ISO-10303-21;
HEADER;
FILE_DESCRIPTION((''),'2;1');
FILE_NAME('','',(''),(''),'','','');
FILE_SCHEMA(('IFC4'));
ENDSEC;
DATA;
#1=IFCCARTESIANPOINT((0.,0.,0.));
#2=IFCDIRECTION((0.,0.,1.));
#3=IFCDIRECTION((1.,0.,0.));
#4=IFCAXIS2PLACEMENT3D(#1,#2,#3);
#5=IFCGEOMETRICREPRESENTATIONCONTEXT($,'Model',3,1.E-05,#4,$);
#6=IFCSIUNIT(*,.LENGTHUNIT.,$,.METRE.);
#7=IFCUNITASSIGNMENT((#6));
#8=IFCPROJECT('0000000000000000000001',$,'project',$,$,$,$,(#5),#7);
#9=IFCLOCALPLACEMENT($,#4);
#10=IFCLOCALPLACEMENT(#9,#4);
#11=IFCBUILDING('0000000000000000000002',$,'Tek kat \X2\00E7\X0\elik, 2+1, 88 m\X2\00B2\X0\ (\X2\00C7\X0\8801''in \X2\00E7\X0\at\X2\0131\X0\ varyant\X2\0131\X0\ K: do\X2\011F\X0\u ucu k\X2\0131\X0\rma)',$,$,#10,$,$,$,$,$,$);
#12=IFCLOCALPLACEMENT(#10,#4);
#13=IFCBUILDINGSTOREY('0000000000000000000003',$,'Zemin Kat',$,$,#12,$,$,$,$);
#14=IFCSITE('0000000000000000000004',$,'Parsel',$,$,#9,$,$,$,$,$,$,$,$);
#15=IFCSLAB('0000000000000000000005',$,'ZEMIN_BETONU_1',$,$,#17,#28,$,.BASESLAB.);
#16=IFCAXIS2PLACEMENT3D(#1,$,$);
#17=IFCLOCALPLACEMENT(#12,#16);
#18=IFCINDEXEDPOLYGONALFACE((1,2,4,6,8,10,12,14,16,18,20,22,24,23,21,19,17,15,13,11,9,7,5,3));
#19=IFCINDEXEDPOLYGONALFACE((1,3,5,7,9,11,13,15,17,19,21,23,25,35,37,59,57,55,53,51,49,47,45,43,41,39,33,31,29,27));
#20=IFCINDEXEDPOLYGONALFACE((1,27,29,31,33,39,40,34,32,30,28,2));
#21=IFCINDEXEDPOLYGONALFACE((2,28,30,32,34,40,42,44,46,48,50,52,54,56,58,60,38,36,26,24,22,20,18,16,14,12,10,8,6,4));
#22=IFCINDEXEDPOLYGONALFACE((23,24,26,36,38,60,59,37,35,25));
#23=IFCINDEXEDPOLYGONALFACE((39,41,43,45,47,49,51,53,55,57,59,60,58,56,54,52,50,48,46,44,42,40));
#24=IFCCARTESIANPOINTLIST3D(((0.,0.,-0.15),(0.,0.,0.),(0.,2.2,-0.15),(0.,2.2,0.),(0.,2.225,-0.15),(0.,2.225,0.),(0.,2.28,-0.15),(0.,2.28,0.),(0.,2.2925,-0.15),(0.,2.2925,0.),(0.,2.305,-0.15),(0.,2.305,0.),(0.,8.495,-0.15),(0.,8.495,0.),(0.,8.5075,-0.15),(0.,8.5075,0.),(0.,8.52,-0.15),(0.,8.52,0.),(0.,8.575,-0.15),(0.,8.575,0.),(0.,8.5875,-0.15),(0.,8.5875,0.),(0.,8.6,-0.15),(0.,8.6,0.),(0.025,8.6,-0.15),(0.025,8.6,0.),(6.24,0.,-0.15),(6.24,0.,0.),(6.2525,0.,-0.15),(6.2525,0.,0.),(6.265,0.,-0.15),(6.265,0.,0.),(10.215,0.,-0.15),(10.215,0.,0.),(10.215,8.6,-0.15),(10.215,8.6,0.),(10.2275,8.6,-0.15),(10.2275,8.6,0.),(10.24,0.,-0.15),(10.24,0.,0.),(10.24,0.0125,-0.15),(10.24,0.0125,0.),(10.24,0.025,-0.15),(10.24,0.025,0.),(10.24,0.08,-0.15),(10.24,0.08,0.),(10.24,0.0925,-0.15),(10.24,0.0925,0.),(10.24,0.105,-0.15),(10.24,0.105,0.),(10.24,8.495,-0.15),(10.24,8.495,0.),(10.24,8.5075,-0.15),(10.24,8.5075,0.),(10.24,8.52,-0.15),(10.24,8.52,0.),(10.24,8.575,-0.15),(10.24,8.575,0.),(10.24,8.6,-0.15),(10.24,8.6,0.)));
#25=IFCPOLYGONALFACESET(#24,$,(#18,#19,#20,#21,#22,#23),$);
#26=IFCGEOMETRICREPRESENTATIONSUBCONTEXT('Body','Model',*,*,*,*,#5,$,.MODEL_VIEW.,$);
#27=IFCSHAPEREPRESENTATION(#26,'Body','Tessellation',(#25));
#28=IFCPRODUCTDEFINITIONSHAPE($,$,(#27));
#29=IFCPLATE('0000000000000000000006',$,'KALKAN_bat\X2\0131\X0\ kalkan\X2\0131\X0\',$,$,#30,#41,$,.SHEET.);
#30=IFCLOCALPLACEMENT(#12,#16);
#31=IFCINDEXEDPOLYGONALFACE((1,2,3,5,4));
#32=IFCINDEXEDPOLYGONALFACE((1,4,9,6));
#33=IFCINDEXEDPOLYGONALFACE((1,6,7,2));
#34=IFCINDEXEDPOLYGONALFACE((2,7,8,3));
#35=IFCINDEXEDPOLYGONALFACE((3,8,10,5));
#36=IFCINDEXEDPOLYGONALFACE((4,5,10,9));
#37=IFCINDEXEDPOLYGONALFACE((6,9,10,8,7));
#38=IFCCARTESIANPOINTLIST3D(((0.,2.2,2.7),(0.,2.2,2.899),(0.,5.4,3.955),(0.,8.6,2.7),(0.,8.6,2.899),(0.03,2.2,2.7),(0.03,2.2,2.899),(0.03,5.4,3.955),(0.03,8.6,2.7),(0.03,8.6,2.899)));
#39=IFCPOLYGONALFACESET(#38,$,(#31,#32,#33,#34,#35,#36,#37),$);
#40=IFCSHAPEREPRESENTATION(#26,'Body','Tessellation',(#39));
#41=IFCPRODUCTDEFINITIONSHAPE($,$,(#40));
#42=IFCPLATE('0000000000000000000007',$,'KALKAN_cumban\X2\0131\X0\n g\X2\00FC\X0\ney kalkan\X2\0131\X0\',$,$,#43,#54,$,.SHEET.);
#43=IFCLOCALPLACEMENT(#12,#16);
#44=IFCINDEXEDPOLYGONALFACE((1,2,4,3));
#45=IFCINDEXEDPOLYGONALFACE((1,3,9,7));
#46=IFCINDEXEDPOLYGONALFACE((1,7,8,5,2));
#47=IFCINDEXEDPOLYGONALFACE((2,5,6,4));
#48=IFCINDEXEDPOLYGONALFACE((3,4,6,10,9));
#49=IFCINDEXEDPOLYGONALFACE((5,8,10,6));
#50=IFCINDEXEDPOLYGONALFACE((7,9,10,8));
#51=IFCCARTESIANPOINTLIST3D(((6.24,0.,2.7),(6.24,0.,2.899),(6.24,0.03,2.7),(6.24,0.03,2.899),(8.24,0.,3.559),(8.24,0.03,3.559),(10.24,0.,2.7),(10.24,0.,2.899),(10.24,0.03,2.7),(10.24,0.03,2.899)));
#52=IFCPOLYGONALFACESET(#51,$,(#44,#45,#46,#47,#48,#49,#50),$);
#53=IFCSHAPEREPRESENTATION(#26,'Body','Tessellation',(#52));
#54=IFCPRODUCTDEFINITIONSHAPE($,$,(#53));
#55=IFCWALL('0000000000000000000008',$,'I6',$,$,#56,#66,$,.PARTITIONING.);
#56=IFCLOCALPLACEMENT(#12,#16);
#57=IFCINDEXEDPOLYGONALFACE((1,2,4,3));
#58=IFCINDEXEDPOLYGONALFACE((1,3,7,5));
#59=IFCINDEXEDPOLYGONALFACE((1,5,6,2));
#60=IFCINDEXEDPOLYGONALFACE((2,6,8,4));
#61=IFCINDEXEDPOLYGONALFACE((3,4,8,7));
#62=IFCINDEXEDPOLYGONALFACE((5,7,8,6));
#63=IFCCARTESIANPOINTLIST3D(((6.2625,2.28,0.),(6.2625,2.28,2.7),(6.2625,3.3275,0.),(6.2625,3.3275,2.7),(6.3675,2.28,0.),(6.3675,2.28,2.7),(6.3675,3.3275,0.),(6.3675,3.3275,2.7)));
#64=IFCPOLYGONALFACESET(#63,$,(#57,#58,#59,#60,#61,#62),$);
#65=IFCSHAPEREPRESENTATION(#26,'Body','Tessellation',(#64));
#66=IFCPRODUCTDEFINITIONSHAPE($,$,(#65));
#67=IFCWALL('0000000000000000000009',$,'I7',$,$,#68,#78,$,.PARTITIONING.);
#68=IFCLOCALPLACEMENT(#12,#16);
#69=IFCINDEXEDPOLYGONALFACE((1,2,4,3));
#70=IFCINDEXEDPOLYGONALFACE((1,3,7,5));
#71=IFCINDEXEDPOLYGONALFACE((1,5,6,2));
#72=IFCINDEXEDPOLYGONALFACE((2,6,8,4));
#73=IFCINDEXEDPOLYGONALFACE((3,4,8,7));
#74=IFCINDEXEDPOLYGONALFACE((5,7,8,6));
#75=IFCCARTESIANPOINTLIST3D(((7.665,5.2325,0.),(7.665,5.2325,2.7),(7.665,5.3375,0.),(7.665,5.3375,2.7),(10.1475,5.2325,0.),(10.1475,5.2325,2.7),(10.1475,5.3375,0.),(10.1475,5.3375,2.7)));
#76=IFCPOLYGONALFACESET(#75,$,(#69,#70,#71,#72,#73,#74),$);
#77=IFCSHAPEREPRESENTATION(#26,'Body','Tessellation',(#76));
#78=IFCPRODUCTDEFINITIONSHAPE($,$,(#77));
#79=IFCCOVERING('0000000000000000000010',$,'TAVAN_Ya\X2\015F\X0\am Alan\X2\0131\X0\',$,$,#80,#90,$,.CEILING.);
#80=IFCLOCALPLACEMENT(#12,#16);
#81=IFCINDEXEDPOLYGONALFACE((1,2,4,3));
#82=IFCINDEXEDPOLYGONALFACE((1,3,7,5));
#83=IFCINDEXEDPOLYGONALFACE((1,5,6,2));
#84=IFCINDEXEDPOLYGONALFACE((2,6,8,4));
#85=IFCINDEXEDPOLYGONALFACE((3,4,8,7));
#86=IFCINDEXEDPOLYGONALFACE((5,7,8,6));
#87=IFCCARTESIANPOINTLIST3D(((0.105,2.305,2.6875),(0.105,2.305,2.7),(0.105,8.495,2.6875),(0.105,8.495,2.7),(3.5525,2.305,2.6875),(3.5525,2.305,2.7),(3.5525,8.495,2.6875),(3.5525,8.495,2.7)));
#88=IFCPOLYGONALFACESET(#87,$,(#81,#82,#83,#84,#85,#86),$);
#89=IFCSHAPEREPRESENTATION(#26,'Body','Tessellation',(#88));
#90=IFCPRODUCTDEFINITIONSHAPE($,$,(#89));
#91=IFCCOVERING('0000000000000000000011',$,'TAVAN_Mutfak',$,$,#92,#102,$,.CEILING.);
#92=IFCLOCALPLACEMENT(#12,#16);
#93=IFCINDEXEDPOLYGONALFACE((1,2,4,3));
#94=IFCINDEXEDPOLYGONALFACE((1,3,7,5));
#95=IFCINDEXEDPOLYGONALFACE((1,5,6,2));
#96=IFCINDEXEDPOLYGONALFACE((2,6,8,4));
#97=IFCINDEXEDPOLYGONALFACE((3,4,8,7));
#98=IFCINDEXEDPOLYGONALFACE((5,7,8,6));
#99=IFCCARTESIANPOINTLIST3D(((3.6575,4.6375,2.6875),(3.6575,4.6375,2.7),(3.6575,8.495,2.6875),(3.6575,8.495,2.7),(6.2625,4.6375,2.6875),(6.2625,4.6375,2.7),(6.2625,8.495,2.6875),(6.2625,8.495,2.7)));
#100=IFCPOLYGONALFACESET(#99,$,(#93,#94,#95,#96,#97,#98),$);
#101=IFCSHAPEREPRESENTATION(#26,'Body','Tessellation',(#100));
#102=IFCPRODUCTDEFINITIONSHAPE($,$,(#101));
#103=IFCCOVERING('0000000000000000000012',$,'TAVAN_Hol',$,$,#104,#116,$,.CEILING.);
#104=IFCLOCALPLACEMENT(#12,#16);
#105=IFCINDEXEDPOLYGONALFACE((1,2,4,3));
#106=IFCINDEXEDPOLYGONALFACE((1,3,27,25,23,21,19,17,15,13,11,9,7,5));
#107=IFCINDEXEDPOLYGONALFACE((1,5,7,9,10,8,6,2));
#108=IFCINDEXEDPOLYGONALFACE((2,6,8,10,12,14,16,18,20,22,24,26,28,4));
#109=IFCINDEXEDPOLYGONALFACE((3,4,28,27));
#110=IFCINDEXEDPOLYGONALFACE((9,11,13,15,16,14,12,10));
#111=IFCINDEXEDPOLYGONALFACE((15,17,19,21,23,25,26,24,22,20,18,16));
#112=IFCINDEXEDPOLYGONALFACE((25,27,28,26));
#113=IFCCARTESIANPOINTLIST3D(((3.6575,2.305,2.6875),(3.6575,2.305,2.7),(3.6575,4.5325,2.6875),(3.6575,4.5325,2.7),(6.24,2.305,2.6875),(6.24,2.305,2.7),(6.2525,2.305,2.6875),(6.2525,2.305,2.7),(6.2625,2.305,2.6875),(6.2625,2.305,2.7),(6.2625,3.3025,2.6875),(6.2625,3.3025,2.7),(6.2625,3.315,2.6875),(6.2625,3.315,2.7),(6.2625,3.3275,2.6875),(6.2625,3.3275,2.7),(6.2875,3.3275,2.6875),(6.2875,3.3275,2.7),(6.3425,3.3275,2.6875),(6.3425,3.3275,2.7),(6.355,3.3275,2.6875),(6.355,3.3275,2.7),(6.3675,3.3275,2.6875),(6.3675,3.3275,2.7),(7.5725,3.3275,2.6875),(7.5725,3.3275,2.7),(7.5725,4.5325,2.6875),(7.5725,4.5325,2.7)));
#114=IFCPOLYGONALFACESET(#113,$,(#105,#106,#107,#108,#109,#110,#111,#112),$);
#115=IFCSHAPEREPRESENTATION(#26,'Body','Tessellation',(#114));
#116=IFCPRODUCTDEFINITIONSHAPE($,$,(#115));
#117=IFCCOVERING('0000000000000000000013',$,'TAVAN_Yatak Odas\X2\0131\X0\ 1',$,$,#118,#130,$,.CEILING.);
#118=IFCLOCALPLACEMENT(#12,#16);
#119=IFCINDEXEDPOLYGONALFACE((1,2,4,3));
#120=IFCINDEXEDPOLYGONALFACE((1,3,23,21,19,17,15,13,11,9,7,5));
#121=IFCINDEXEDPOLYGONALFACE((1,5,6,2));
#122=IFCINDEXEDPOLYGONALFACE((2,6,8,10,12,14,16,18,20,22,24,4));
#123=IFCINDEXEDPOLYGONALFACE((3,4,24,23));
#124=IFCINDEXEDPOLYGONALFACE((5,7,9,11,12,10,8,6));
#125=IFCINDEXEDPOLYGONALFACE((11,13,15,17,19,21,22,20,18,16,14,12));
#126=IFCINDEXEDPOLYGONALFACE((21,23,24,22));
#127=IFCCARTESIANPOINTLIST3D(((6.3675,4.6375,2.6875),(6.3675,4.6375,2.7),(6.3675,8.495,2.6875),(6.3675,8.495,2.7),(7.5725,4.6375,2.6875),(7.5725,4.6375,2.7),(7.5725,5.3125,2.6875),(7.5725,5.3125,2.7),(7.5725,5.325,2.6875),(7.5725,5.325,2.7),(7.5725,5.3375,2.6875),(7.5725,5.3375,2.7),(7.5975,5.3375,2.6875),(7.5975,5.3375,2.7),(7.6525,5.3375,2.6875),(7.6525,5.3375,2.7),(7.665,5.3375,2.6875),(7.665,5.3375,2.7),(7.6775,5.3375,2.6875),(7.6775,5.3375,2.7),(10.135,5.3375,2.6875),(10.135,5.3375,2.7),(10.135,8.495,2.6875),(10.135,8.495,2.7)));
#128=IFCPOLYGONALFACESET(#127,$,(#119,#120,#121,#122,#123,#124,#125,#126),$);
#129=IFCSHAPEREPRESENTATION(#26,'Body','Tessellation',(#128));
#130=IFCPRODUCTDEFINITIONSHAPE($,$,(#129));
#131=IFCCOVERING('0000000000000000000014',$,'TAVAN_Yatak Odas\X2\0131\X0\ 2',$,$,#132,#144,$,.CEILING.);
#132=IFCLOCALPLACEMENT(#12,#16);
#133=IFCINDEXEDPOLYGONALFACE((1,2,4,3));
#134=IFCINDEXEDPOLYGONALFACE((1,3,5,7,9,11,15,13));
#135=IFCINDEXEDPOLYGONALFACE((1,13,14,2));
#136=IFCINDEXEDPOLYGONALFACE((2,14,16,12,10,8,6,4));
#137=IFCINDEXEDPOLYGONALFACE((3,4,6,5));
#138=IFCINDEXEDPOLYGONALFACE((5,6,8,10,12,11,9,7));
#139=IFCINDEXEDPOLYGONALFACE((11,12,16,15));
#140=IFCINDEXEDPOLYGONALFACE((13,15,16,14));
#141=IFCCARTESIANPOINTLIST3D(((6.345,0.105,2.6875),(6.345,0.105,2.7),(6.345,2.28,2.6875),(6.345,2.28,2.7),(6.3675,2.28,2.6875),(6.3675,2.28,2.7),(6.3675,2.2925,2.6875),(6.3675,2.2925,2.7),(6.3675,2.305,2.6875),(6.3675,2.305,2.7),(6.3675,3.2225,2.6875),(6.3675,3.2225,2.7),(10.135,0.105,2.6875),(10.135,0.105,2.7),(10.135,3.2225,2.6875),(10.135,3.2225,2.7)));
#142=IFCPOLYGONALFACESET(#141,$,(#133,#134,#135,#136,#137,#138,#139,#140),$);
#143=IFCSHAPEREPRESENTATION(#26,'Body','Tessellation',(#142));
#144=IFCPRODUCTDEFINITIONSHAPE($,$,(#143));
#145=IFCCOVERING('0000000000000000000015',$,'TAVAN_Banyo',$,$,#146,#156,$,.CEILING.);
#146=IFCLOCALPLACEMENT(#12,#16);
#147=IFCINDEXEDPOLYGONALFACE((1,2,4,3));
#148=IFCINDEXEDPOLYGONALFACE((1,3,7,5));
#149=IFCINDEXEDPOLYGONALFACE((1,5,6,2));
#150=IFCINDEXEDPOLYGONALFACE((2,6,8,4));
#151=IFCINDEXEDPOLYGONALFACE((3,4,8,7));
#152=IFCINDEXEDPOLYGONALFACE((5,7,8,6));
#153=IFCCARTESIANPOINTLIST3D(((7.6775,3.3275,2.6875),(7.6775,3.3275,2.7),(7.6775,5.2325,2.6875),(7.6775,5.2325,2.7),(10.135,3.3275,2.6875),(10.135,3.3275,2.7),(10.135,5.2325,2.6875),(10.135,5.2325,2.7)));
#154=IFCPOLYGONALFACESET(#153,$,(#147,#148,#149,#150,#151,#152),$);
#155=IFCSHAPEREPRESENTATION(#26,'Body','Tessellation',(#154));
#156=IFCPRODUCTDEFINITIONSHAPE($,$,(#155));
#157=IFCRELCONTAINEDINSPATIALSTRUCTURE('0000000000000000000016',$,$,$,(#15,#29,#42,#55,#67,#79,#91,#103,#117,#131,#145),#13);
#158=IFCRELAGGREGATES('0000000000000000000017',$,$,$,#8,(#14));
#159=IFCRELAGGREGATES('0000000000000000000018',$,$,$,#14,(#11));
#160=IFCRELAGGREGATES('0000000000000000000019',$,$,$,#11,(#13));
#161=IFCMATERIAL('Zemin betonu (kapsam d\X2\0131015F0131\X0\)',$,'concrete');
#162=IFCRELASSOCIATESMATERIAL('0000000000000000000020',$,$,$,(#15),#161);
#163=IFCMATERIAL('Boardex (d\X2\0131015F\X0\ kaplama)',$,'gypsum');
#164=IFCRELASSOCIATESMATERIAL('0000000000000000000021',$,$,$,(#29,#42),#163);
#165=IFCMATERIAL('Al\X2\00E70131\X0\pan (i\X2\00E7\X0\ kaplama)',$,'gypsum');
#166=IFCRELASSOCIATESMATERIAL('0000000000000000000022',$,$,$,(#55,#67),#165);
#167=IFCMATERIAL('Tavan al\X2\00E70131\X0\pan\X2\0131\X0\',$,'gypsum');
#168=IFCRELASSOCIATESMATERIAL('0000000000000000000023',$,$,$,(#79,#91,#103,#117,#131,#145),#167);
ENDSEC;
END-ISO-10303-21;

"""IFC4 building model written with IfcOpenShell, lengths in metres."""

from ifc_helpers import new_model, si_unit, frame, origin_with_axes, place, context, subcontext, project, spatial, line, indexed_curve, outline, extrude, material, element, save


model = new_model("IFC4")

# Units and contexts
model_context = context("Model", 3, precision=1e-05, world=origin_with_axes())
body_context = subcontext(model_context, "Body", "Model", "MODEL_VIEW")
ifc_project = project(units=[si_unit("LENGTHUNIT", "METRE")], contexts=[model_context])

# Site, building, storey
site_placement = place(None, origin_with_axes())
site = spatial("IfcSite", under=ifc_project, at=site_placement, Name="Parsel")
building_placement = place(site_placement, origin_with_axes())
building = spatial("IfcBuilding", under=site, at=building_placement, Name="Tek kat çelik, 2+1, 88 m² (Ç8801'in çatı varyantı K: doğu ucu kırma)")
storey_placement = place(building_placement, origin_with_axes())
storey = spatial("IfcBuildingStorey", under=building, at=storey_placement, Name="Zemin Kat")

# Slab
ifc_material_1 = material(Name="Zemin betonu (kapsam dışı)", Category="concrete")
slab_placement = place(storey_placement, origin_with_axes())
element("IfcSlab", 1, at=slab_placement, inside=storey, material=ifc_material_1, Name="ZEMIN_BETONU_1", PredefinedType="BASESLAB", context=body_context, shape_type="SweptSolid", body=[
    extrude(outline(indexed_curve([(6.24, 0.0), (6.2525, 0.0), (6.265, 0.0), (10.215, 0.0), (10.24, 0.0), (10.24, 0.0125), (10.24, 0.025), (10.24, 0.08), (10.24, 0.0925), (10.24, 0.105), (10.24, 8.495), (10.24, 8.5075), (10.24, 8.52), (10.24, 8.575), (10.24, 8.6), (10.2275, 8.6), (10.215, 8.6), (0.025, 8.6), (0.0, 8.6), (0.0, 8.5875), (0.0, 8.575), (0.0, 8.52), (0.0, 8.5075), (0.0, 8.495), (0.0, 2.305), (0.0, 2.2925), (0.0, 2.28), (0.0, 2.225), (0.0, 2.2), (0.0, 0.0)], segments=[line(1, 2, 3, 4, 5, 6, 7, 8, 9, 10, 11, 12, 13, 14, 15, 16, 17, 18, 19, 20, 21, 22, 23, 24, 25, 26, 27, 28, 29, 30, 1)])), frame((0.0, 0.0, -0.15), z_axis=(0.0, 0.0, 1.0), x_axis=(1.0, 0.0, 0.0)), (0.0, 0.0, 1.0), 0.15),
])

# Plates
ifc_material_2 = material(Name="Boardex (dış kaplama)", Category="gypsum")
plate_1_placement = place(storey_placement, origin_with_axes())
element("IfcPlate", 2, at=plate_1_placement, inside=storey, material=ifc_material_2, Name="KALKAN_batı kalkanı", PredefinedType="SHEET", context=body_context, shape_type="SweptSolid", body=[
    extrude(outline(indexed_curve([(2.2, 2.899), (5.4, 3.955), (8.6, 2.899), (8.6, 2.7), (2.2, 2.7)], segments=[line(1, 2, 3, 4, 5, 1)])), frame((0.0, 0.0, 0.0), z_axis=(1.0, 0.0, 0.0), x_axis=(0.0, 1.0, 0.0)), (0.0, 0.0, 1.0), 0.03),
])
plate_2_placement = place(storey_placement, origin_with_axes())
element("IfcPlate", 3, at=plate_2_placement, inside=storey, material=ifc_material_2, Name="KALKAN_cumbanın güney kalkanı", PredefinedType="SHEET", context=body_context, shape_type="SweptSolid", body=[
    extrude(outline(indexed_curve([(6.24, 2.899), (8.24, 3.559), (10.24, 2.899), (10.24, 2.7), (6.24, 2.7)], segments=[line(1, 2, 3, 4, 5, 1)])), frame((0.0, 0.03, 0.0), z_axis=(0.0, -1.0, 0.0), x_axis=(1.0, 0.0, 0.0)), (0.0, 0.0, 1.0), 0.03),
])

# Walls
ifc_material_3 = material(Name="Alçıpan (iç kaplama)", Category="gypsum")
wall_1_placement = place(storey_placement, origin_with_axes())
element("IfcWall", 4, at=wall_1_placement, inside=storey, material=ifc_material_3, Name="I6", PredefinedType="PARTITIONING", context=body_context, shape_type="SweptSolid", body=[
    extrude(outline(indexed_curve([(0.0, 0.0), (0.105, 0.0), (0.105, 1.0475), (0.0, 1.0475)], segments=[line(1, 2, 3, 4, 1)])), frame((6.2625, 2.28, 0.0), z_axis=(0.0, 0.0, 1.0), x_axis=(1.0, 0.0, 0.0)), (0.0, 0.0, 1.0), 2.7),
])
wall_2_placement = place(storey_placement, origin_with_axes())
element("IfcWall", 5, at=wall_2_placement, inside=storey, material=ifc_material_3, Name="I7", PredefinedType="PARTITIONING", context=body_context, shape_type="SweptSolid", body=[
    extrude(outline(indexed_curve([(0.0, 0.0), (2.4825, 0.0), (2.4825, 0.105), (0.0, 0.105)], segments=[line(1, 2, 3, 4, 1)])), frame((7.665, 5.2325, 0.0), z_axis=(0.0, 0.0, 1.0), x_axis=(1.0, 0.0, 0.0)), (0.0, 0.0, 1.0), 2.7),
])

# Coverings
ifc_material_4 = material(Name="Tavan alçıpanı", Category="gypsum")
covering_1_placement = place(storey_placement, origin_with_axes())
element("IfcCovering", 6, at=covering_1_placement, inside=storey, material=ifc_material_4, Name="TAVAN_Yaşam Alanı", PredefinedType="CEILING", context=body_context, shape_type="SweptSolid", body=[
    extrude(outline(indexed_curve([(0.105, 8.495), (3.5525, 8.495), (3.5525, 2.305), (0.105, 2.305)], segments=[line(1, 2, 3, 4, 1)])), frame((0.0, 0.0, 2.6875), z_axis=(0.0, 0.0, 1.0), x_axis=(1.0, 0.0, 0.0)), (0.0, 0.0, 1.0), 0.0125),
])
covering_2_placement = place(storey_placement, origin_with_axes())
element("IfcCovering", 7, at=covering_2_placement, inside=storey, material=ifc_material_4, Name="TAVAN_Mutfak", PredefinedType="CEILING", context=body_context, shape_type="SweptSolid", body=[
    extrude(outline(indexed_curve([(3.6575, 8.495), (6.2625, 8.495), (6.2625, 4.6375), (3.6575, 4.6375)], segments=[line(1, 2, 3, 4, 1)])), frame((0.0, 0.0, 2.6875), z_axis=(0.0, 0.0, 1.0), x_axis=(1.0, 0.0, 0.0)), (0.0, 0.0, 1.0), 0.0125),
])
covering_3_placement = place(storey_placement, origin_with_axes())
element("IfcCovering", 8, at=covering_3_placement, inside=storey, material=ifc_material_4, Name="TAVAN_Hol", PredefinedType="CEILING", context=body_context, shape_type="SweptSolid", body=[
    extrude(outline(indexed_curve([(6.24, 2.305), (3.6575, 2.305), (3.6575, 4.5325), (7.5725, 4.5325), (7.5725, 3.3275), (6.3675, 3.3275), (6.355, 3.3275), (6.3425, 3.3275), (6.2875, 3.3275), (6.2625, 3.3275), (6.2625, 3.315), (6.2625, 3.3025), (6.2625, 2.305), (6.2525, 2.305)], segments=[line(1, 2, 3, 4, 5, 6, 7, 8, 9, 10, 11, 12, 13, 14, 1)])), frame((0.0, 0.0, 2.6875), z_axis=(0.0, 0.0, 1.0), x_axis=(1.0, 0.0, 0.0)), (0.0, 0.0, 1.0), 0.0125),
])
covering_4_placement = place(storey_placement, origin_with_axes())
element("IfcCovering", 9, at=covering_4_placement, inside=storey, material=ifc_material_4, Name="TAVAN_Yatak Odası 1", PredefinedType="CEILING", context=body_context, shape_type="SweptSolid", body=[
    extrude(outline(indexed_curve([(6.3675, 8.495), (10.135, 8.495), (10.135, 5.3375), (7.6775, 5.3375), (7.665, 5.3375), (7.6525, 5.3375), (7.5975, 5.3375), (7.5725, 5.3375), (7.5725, 5.325), (7.5725, 5.3125), (7.5725, 4.6375), (6.3675, 4.6375)], segments=[line(1, 2, 3, 4, 5, 6, 7, 8, 9, 10, 11, 12, 1)])), frame((0.0, 0.0, 2.6875), z_axis=(0.0, 0.0, 1.0), x_axis=(1.0, 0.0, 0.0)), (0.0, 0.0, 1.0), 0.0125),
])
covering_5_placement = place(storey_placement, origin_with_axes())
element("IfcCovering", 10, at=covering_5_placement, inside=storey, material=ifc_material_4, Name="TAVAN_Yatak Odası 2", PredefinedType="CEILING", context=body_context, shape_type="SweptSolid", body=[
    extrude(outline(indexed_curve([(6.3675, 3.2225), (10.135, 3.2225), (10.135, 0.105), (6.345, 0.105), (6.345, 2.28), (6.3675, 2.28), (6.3675, 2.2925), (6.3675, 2.305)], segments=[line(1, 2, 3, 4, 5, 6, 7, 8, 1)])), frame((0.0, 0.0, 2.6875), z_axis=(0.0, 0.0, 1.0), x_axis=(1.0, 0.0, 0.0)), (0.0, 0.0, 1.0), 0.0125),
])
covering_6_placement = place(storey_placement, origin_with_axes())
element("IfcCovering", 11, at=covering_6_placement, inside=storey, material=ifc_material_4, Name="TAVAN_Banyo", PredefinedType="CEILING", context=body_context, shape_type="SweptSolid", body=[
    extrude(outline(indexed_curve([(7.6775, 5.2325), (10.135, 5.2325), (10.135, 3.3275), (7.6775, 3.3275)], segments=[line(1, 2, 3, 4, 1)])), frame((0.0, 0.0, 2.6875), z_axis=(0.0, 0.0, 1.0), x_axis=(1.0, 0.0, 0.0)), (0.0, 0.0, 1.0), 0.0125),
])

save(model, "model.ifc")
